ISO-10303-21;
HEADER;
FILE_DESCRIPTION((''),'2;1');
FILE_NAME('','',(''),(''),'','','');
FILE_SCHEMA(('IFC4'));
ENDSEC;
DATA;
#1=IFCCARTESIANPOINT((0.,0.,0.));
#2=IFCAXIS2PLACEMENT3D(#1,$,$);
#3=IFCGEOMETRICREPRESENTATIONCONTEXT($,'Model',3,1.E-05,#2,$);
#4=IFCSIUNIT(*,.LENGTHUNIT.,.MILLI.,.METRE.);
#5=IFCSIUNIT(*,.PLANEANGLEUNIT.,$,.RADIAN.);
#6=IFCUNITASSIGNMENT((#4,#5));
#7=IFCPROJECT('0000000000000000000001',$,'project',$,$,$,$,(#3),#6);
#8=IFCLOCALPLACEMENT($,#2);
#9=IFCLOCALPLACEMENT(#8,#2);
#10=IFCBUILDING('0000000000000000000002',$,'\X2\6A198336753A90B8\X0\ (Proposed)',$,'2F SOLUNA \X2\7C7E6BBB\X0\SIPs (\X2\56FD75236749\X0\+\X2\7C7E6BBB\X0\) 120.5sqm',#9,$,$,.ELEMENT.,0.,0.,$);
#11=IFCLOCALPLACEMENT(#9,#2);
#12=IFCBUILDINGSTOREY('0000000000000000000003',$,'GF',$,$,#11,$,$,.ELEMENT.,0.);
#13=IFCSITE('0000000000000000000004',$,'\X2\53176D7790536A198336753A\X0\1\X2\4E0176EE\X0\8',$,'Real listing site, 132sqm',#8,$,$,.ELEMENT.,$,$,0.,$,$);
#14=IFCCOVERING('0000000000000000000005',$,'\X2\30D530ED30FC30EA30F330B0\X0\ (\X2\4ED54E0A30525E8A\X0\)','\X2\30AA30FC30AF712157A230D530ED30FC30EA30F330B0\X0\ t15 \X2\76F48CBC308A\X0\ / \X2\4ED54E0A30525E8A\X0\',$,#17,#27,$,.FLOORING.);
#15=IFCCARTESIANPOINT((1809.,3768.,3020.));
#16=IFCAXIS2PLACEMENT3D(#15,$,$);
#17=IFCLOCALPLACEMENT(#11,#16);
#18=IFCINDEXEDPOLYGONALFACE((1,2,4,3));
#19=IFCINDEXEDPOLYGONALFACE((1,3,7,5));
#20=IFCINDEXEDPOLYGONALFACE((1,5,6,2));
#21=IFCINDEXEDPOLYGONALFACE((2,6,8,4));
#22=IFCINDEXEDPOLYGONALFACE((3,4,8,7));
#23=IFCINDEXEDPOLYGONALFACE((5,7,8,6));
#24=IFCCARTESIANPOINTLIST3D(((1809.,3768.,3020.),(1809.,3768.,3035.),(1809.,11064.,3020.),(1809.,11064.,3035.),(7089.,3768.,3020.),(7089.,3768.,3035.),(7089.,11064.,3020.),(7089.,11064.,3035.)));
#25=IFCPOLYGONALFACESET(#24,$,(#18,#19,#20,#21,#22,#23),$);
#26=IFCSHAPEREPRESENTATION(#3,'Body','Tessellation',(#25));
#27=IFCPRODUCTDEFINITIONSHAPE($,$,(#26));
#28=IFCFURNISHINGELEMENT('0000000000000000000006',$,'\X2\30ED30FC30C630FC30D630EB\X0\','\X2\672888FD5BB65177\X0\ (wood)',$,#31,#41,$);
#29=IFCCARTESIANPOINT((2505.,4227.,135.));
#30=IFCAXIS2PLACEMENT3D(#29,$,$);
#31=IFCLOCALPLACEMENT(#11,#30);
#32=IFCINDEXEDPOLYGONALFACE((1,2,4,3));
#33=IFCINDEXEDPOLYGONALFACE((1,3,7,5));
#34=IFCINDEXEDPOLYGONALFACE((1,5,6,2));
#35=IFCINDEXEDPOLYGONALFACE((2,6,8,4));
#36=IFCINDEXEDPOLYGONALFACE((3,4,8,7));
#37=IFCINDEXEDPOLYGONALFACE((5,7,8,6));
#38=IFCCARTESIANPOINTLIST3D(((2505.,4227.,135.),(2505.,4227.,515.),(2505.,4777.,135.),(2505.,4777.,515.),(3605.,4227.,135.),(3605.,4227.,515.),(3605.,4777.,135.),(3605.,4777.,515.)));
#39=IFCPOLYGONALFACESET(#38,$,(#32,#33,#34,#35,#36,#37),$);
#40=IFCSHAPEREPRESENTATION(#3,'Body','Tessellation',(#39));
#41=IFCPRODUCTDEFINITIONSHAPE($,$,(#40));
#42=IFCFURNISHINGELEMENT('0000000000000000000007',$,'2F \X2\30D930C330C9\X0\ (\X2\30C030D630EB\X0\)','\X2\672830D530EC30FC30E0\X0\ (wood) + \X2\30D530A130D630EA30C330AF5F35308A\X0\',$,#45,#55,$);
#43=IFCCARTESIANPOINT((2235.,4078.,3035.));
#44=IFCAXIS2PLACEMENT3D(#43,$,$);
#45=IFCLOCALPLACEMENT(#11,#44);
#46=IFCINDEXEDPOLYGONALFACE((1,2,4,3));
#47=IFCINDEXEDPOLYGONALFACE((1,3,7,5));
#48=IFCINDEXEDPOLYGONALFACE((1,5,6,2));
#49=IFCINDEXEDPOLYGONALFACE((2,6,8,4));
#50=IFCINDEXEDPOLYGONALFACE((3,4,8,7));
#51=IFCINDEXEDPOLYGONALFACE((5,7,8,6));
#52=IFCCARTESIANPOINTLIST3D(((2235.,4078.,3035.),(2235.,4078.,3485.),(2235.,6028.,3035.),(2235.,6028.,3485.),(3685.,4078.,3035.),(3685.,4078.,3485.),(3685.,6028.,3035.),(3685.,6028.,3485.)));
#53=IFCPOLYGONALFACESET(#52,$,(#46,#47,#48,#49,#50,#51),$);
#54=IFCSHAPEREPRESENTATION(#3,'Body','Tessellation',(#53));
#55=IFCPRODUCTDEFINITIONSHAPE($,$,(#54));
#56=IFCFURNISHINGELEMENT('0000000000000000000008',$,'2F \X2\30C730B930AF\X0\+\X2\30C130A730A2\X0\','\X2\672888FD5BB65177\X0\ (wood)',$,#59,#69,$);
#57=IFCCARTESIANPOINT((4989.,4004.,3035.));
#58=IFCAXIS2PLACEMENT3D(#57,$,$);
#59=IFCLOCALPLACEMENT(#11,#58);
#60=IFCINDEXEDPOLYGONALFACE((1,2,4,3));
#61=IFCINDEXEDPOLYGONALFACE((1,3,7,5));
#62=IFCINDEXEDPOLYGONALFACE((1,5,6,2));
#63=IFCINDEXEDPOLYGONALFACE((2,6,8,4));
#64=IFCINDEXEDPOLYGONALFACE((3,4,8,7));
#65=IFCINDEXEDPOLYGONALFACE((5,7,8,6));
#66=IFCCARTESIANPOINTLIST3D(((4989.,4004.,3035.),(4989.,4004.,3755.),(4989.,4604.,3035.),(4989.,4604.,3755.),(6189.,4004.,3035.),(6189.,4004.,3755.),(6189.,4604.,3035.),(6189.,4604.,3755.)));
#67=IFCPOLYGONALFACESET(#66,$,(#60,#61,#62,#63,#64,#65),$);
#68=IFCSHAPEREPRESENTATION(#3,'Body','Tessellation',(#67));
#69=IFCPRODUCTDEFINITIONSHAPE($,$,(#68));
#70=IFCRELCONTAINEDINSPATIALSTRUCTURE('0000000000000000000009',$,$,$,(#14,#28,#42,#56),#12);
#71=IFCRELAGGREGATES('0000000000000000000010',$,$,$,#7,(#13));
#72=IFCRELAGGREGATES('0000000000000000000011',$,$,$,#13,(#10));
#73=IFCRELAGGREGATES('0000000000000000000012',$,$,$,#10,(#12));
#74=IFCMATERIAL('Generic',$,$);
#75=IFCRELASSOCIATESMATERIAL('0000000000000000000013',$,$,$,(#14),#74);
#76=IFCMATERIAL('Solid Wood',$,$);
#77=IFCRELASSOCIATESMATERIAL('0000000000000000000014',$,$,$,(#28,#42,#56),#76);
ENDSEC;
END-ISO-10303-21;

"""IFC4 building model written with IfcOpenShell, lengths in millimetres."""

from ifc_helpers import new_model, si_unit, frame, frame_2d, origin, place, context, project, spatial, rectangle, extrude, material, element, save


model = new_model("IFC4")

# Units and contexts
model_context = context("Model", 3, precision=1e-05, world=origin())
ifc_project = project(units=[si_unit("LENGTHUNIT", "METRE", prefix="MILLI"), si_unit("PLANEANGLEUNIT", "RADIAN")], contexts=[model_context])

# Site, building, storey
site_placement = place(None, origin())
site = spatial("IfcSite", under=ifc_project, at=site_placement, Name="北海道標茶町1丁目8", ObjectType="Real listing site, 132sqm", CompositionType="ELEMENT", RefElevation=0.0)
building_placement = place(site_placement, origin())
building = spatial("IfcBuilding", under=site, at=building_placement, Name="標茶町邸 (Proposed)", ObjectType="2F SOLUNA 籾殻SIPs (国産杉+籾殻) 120.5sqm", CompositionType="ELEMENT", ElevationOfRefHeight=0.0, ElevationOfTerrain=0.0)
storey_placement = place(building_placement, origin())
storey = spatial("IfcBuildingStorey", under=building, at=storey_placement, Name="GF", CompositionType="ELEMENT", Elevation=0.0)

# Shared definitions
ifc_material_1 = material(Name="Solid Wood")

# Shared definitions
ifc_material_2 = material(Name="Generic")

# Covering
covering_placement = place(storey_placement, frame((1809.0, 3768.0, 3020.0)))
element("IfcCovering", 1, at=covering_placement, inside=storey, material=ifc_material_2, Name="フローリング (仕上げ床)", Description="オーク無垢フローリング t15 直貼り / 仕上げ床", PredefinedType="FLOORING", context=model_context, shape_type="SweptSolid", body=[
    extrude(rectangle(XDim=5280.0, YDim=7296.0, at=frame_2d((2640.0, 3648.0))), frame((1809.0, 3768.0, 3020.0)), (0.0, 0.0, 1.0), 15.0),
])

# Furnishing elements
furnishing_1_placement = place(storey_placement, frame((2505.0, 4227.0, 135.0)))
element("IfcFurnishingElement", 2, at=furnishing_1_placement, inside=storey, material=ifc_material_1, Name="ローテーブル", Description="木製家具 (wood)", context=model_context, shape_type="SweptSolid", body=[
    extrude(rectangle(XDim=1100.0, YDim=550.0, at=frame_2d((550.0, 275.0))), frame((2505.0, 4227.0, 135.0)), (0.0, 0.0, 1.0), 380.0),
])
furnishing_2_placement = place(storey_placement, frame((2235.0, 4078.0, 3035.0)))
element("IfcFurnishingElement", 3, at=furnishing_2_placement, inside=storey, material=ifc_material_1, Name="2F ベッド (ダブル)", Description="木フレーム (wood) + ファブリック張り", context=model_context, shape_type="SweptSolid", body=[
    extrude(rectangle(XDim=1450.0, YDim=1950.0, at=frame_2d((725.0, 975.0))), frame((2235.0, 4078.0, 3035.0)), (0.0, 0.0, 1.0), 450.0),
])
furnishing_3_placement = place(storey_placement, frame((4989.0, 4004.0, 3035.0)))
element("IfcFurnishingElement", 4, at=furnishing_3_placement, inside=storey, material=ifc_material_1, Name="2F デスク+チェア", Description="木製家具 (wood)", context=model_context, shape_type="SweptSolid", body=[
    extrude(rectangle(XDim=1200.0, YDim=600.0, at=frame_2d((600.0, 300.0))), frame((4989.0, 4004.0, 3035.0)), (0.0, 0.0, 1.0), 720.0),
])

save(model, "model.ifc")
